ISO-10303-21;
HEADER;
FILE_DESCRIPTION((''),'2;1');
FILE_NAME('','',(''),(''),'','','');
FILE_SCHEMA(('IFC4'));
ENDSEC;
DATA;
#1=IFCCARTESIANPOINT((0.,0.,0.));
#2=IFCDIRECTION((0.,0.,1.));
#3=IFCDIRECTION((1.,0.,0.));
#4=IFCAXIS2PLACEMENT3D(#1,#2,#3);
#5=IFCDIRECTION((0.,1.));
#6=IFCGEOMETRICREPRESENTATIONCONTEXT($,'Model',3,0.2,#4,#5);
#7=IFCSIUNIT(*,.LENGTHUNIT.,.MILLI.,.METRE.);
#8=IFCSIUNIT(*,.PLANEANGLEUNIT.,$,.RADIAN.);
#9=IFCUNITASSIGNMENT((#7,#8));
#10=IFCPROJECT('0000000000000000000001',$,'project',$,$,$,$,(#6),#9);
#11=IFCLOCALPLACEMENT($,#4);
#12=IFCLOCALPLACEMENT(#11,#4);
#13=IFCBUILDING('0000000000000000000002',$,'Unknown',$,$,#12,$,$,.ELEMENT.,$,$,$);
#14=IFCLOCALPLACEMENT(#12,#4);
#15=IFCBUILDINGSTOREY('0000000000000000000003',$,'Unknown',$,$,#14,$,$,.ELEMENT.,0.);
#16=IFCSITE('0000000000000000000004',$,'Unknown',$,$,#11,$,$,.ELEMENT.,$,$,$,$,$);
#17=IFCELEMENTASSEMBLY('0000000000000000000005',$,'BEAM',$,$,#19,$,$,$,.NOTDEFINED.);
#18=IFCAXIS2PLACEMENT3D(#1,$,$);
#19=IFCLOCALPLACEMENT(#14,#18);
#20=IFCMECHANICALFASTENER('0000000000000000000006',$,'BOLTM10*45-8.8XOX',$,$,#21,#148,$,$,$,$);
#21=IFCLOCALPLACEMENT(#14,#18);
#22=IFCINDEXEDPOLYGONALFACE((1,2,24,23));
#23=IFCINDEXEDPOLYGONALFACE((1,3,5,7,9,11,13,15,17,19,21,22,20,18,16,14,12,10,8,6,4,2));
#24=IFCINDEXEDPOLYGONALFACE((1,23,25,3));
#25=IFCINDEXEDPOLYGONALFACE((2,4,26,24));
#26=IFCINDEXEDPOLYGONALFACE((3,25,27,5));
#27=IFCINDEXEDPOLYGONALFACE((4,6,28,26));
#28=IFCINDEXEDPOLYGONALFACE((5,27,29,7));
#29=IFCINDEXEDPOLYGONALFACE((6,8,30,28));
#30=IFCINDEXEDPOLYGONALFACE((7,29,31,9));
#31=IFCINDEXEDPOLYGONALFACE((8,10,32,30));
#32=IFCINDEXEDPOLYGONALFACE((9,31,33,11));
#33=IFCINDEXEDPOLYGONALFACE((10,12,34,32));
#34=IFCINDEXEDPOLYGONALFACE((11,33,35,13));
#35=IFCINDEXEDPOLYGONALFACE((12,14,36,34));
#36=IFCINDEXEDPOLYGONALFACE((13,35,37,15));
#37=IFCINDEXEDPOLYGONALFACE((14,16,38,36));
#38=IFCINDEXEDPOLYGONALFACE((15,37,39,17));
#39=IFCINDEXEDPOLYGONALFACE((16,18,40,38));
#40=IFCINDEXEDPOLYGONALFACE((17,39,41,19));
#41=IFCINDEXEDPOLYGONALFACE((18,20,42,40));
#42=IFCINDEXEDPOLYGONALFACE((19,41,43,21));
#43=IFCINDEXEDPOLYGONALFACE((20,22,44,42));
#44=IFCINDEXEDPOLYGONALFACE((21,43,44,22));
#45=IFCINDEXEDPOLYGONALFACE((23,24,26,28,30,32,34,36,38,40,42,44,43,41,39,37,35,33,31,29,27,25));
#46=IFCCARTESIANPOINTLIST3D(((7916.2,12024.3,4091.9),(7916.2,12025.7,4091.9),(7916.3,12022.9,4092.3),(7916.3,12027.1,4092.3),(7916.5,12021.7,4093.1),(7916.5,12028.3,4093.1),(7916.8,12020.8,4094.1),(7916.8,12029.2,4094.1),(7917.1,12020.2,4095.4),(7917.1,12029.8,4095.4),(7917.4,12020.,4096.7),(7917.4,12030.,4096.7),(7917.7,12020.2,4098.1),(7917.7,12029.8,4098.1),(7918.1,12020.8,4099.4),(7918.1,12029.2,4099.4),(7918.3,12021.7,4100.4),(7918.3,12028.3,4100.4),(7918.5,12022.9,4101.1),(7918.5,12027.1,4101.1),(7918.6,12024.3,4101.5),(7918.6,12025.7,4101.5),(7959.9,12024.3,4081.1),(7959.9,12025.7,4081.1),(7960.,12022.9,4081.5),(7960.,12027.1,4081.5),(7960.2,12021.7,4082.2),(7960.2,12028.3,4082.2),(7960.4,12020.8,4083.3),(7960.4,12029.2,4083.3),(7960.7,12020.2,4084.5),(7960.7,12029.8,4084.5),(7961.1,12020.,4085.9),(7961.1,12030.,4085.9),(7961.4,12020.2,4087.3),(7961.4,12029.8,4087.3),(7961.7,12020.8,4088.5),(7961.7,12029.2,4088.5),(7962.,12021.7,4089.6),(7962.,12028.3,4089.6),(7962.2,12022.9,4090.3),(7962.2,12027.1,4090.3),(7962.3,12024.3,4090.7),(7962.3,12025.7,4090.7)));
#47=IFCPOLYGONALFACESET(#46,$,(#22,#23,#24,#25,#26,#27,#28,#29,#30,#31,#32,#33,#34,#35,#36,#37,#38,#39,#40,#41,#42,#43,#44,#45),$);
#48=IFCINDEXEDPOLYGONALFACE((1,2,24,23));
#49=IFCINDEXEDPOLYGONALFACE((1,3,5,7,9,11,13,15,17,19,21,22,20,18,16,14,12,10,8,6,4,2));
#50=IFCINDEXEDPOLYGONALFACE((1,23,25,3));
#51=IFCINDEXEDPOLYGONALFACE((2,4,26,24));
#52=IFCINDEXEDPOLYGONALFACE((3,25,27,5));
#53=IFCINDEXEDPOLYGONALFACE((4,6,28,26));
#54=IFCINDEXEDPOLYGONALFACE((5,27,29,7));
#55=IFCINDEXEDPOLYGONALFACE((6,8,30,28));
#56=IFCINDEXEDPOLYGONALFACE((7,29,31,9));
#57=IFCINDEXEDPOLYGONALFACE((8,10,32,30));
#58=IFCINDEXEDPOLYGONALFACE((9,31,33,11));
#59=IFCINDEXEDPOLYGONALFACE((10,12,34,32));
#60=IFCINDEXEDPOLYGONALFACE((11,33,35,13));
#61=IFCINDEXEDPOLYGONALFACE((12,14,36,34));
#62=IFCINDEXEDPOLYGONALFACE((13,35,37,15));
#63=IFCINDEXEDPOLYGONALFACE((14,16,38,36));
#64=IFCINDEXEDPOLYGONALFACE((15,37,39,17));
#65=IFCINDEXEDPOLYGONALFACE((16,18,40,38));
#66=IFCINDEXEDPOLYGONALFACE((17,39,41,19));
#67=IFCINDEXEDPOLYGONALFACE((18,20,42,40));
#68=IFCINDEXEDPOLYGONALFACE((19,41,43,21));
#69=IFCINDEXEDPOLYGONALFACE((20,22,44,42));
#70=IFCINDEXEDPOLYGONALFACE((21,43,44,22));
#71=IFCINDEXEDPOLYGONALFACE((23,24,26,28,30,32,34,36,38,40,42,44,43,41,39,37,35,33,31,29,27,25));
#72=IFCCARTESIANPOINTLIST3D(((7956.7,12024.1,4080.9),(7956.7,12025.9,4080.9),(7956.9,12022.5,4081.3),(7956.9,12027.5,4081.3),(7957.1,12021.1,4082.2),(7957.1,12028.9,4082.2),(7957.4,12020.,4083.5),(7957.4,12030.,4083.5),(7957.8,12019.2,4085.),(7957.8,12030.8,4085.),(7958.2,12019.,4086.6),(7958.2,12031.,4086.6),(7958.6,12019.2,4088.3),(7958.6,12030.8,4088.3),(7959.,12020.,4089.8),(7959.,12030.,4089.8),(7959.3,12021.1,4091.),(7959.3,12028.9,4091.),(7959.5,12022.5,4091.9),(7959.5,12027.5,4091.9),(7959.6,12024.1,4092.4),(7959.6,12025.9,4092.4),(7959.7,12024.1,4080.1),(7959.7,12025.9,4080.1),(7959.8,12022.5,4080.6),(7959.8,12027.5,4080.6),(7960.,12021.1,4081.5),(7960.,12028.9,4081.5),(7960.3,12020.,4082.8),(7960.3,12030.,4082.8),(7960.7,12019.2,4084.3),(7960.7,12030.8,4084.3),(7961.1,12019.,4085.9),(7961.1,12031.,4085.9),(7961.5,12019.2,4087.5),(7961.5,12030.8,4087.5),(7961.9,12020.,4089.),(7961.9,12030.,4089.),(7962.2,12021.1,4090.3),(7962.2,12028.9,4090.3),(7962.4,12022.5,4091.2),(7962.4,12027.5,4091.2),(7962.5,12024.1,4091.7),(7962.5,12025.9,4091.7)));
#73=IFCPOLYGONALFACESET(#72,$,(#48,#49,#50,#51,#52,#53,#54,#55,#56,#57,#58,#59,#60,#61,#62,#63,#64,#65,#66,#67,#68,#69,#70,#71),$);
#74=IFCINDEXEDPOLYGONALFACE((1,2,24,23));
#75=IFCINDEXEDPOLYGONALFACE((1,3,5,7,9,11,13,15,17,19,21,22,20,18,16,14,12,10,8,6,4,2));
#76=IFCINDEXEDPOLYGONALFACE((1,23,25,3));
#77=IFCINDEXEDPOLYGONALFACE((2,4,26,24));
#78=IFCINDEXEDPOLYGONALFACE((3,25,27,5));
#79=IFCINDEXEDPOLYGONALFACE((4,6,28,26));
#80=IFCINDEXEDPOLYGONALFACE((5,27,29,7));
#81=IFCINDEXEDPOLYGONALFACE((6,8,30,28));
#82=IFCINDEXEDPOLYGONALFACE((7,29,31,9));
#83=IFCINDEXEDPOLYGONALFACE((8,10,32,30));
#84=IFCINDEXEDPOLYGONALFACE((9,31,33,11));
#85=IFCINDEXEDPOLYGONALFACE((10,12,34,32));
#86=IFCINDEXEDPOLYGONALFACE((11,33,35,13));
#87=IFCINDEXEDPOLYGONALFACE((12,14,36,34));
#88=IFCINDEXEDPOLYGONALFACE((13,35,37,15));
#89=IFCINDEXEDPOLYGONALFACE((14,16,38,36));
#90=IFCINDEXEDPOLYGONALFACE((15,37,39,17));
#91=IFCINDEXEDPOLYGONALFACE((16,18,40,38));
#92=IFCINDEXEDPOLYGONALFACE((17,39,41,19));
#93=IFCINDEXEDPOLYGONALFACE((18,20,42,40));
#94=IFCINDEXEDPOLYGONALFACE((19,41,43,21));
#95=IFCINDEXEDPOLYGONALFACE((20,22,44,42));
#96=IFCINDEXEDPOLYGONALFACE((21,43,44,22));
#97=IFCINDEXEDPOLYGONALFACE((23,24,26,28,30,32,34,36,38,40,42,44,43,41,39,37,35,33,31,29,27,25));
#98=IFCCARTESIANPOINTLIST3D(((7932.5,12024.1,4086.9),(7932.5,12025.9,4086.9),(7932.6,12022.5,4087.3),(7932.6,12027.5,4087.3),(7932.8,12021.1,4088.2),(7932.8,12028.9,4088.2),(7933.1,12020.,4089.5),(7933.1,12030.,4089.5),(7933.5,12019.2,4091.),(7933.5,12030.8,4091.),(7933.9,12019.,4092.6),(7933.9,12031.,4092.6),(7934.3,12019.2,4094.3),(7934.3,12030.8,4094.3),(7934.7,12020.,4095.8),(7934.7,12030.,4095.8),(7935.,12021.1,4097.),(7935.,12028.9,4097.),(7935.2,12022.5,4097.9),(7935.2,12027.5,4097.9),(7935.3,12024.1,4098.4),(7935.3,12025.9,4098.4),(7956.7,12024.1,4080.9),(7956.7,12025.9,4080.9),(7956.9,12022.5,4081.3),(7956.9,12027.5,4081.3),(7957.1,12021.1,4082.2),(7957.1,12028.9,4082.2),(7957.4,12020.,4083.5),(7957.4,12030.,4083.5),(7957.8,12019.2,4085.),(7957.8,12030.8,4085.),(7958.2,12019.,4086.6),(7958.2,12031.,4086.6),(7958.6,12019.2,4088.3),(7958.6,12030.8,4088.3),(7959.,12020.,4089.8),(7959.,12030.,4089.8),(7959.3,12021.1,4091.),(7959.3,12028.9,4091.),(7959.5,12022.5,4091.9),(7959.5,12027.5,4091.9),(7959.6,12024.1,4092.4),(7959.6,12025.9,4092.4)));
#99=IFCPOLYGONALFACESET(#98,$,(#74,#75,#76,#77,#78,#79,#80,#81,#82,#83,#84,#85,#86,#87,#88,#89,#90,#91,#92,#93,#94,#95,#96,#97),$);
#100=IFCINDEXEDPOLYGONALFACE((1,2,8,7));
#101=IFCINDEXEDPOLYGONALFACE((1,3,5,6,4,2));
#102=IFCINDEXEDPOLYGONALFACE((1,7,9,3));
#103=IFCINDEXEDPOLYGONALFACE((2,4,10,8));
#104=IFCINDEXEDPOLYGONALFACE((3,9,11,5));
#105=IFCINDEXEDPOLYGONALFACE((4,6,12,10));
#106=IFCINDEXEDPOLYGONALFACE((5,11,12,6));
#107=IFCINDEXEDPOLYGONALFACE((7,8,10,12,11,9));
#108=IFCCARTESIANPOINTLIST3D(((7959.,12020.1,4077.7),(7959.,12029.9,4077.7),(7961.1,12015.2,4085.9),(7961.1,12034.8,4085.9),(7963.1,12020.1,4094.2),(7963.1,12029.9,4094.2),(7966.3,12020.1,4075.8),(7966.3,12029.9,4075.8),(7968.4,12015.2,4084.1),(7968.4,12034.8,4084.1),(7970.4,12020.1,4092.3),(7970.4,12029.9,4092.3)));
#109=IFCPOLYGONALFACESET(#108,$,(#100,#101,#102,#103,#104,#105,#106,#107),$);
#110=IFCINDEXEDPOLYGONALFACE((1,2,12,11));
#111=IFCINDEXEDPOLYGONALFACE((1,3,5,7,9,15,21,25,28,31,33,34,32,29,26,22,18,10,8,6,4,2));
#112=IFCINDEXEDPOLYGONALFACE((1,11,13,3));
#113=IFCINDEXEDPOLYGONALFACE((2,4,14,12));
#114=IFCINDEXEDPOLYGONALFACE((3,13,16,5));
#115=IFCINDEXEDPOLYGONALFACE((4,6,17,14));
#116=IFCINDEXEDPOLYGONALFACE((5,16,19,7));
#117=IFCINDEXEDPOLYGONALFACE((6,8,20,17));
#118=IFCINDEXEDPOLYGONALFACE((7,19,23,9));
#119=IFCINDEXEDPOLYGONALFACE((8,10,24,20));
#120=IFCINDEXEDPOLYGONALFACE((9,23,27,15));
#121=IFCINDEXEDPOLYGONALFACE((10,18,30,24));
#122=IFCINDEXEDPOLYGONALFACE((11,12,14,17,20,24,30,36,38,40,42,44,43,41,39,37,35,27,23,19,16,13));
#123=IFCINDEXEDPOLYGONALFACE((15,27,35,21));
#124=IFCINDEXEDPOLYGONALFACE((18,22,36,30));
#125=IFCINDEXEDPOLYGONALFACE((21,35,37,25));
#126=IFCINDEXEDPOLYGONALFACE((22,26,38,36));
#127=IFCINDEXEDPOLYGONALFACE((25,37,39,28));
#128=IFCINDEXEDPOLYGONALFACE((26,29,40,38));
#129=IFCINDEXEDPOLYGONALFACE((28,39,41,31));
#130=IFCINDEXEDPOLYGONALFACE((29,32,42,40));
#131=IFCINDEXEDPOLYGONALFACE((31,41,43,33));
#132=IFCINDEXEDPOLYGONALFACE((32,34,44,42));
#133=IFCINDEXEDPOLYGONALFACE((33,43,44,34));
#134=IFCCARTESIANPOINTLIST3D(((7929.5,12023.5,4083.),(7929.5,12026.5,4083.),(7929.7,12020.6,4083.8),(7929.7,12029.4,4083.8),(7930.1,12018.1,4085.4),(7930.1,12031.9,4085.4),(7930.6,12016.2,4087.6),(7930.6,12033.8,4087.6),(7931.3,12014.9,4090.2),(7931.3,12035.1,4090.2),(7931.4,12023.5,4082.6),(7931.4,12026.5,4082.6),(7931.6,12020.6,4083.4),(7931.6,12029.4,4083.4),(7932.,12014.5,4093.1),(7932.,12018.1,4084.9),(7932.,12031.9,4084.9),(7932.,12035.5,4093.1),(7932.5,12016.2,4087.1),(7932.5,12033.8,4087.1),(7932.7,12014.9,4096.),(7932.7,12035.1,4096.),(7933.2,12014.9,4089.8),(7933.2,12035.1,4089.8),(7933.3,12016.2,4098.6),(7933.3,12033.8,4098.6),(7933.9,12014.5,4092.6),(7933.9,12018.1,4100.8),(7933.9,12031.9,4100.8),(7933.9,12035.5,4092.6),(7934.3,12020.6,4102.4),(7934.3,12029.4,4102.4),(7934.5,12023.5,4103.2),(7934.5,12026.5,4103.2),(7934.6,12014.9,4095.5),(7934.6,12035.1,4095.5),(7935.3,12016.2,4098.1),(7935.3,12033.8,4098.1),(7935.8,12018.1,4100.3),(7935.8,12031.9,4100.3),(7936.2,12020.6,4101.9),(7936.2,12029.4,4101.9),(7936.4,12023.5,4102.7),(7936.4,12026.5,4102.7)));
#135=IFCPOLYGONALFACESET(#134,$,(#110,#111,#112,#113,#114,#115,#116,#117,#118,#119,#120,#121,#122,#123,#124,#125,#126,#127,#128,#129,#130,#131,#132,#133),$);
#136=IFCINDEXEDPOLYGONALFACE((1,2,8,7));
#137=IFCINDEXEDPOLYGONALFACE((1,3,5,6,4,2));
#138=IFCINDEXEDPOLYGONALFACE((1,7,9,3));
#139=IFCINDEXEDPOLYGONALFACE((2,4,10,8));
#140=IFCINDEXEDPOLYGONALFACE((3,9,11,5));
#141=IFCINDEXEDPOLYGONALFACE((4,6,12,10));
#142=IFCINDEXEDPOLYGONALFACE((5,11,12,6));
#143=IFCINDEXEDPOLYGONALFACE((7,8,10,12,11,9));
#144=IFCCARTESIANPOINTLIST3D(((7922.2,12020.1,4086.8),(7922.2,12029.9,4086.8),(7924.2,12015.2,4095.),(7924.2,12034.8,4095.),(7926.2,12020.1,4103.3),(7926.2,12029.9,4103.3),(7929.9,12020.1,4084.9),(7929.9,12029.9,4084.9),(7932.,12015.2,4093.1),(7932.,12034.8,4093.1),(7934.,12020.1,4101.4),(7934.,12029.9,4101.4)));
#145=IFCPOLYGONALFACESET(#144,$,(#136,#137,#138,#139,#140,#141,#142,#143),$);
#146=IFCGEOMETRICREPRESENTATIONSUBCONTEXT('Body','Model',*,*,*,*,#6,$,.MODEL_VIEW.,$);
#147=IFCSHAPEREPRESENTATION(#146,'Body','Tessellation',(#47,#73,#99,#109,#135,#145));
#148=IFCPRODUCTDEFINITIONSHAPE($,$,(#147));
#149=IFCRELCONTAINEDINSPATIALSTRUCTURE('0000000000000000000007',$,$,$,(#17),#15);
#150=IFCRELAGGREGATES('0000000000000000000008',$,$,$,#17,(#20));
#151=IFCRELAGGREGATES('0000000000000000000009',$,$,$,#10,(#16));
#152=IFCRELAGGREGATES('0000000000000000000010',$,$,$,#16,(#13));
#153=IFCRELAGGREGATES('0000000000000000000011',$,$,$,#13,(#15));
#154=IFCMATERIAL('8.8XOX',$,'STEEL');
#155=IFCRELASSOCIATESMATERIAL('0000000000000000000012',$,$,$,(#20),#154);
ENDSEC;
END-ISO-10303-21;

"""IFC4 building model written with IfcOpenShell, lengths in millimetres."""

from ifc_helpers import new_model, si_unit, direction, frame, origin_with_axes, place, context, subcontext, project, spatial, line, arc, indexed_curve, outline, extrude, source, transform, mapped, material, element, aggregate, save


model = new_model("IFC4")

# Units and contexts
model_context = context("Model", 3, precision=0.2, world=origin_with_axes(), true_north=direction((0.0, 1.0)))
body_context = subcontext(model_context, "Body", "Model", "MODEL_VIEW")
ifc_project = project(units=[si_unit("LENGTHUNIT", "METRE", prefix="MILLI"), si_unit("PLANEANGLEUNIT", "RADIAN")], contexts=[model_context])

# Site, building, storey
site_placement = place(None, origin_with_axes())
site = spatial("IfcSite", under=ifc_project, at=site_placement, Name="Unknown", CompositionType="ELEMENT")
building_placement = place(site_placement, origin_with_axes())
building = spatial("IfcBuilding", under=site, at=building_placement, Name="Unknown", CompositionType="ELEMENT")
storey_placement = place(building_placement, origin_with_axes())
storey = spatial("IfcBuildingStorey", under=building, at=storey_placement, Name="Unknown", CompositionType="ELEMENT", Elevation=0.0)

# Shared definitions
ifc_material_1 = material(Name="8.8XOX", Category="STEEL")

# Element assembly, mechanical fastener
shared_shape_1 = source(origin_with_axes(), body_context, "Body", "SweptSolid", [
    extrude(outline(indexed_curve([(5.0, 0.0), (0.0, 5.0), (-5.0, 0.0), (0.0, -5.0)], segments=[arc(1, 2, 3), arc(3, 4, 1)])), frame((0.0, 0.0, 3.8), z_axis=(0.0, 0.0, -1.0), x_axis=(0.0, 1.0, 0.0)), (0.0, 0.0, 1.0), 45.0),
    extrude(outline(indexed_curve([(6.0, 0.0), (0.0, 6.0), (-6.0, 0.0), (0.0, -6.0)], segments=[arc(1, 2, 3), arc(3, 4, 1)])), frame((0.0, 0.0, 3.8), z_axis=(0.0, 0.0, -1.0), x_axis=(0.0, 1.0, 0.0)), (0.0, 0.0, 1.0), 3.0),
    extrude(outline(indexed_curve([(6.0, 0.0), (0.0, 6.0), (-6.0, 0.0), (0.0, -6.0)], segments=[arc(1, 2, 3), arc(3, 4, 1)])), frame((0.0, 0.0, 0.8), z_axis=(0.0, 0.0, -1.0), x_axis=(0.0, 1.0, 0.0)), (0.0, 0.0, 1.0), 25.0),
    extrude(outline(indexed_curve([(9.8, 0.0), (4.9, 8.5), (-4.9, 8.5), (-9.8, 0.0), (-4.9, -8.5), (4.9, -8.5)], segments=[line(1, 2, 3, 4, 5, 6, 1)])), frame((0.0, 0.0, 11.2), z_axis=(0.0, 0.0, -1.0), x_axis=(0.0, 1.0, 0.0)), (0.0, 0.0, 1.0), 7.5),
    extrude(outline(indexed_curve([(10.5, 0.0), (0.0, 10.5), (-10.5, 0.0), (0.0, -10.5)], segments=[arc(1, 2, 3), arc(3, 4, 1)])), frame((0.0, 0.0, -24.2), z_axis=(0.0, 0.0, -1.0), x_axis=(0.0, 1.0, 0.0)), (0.0, 0.0, 1.0), 2.0),
    extrude(outline(indexed_curve([(9.8, 0.0), (4.9, 8.5), (-4.9, 8.5), (-9.8, 0.0), (-4.9, -8.5), (4.9, -8.5)], segments=[line(1, 2, 3, 4, 5, 6, 1)])), frame((0.0, 0.0, -26.2), z_axis=(0.0, 0.0, -1.0), x_axis=(0.0, 1.0, 0.0)), (0.0, 0.0, 1.0), 8.0),
])
assembly_1_placement = place(storey_placement, frame((7947.2, 12000.0, 4094.5), z_axis=(0.970613, 0.0, -0.240648), x_axis=(0.0, 1.0, 0.0)))
assembly_1 = element("IfcElementAssembly", 1, at=assembly_1_placement, inside=storey, Name="BEAM", PredefinedType="NOTDEFINED")
mechanical_fastener_1_placement = place(assembly_1_placement, frame((25.0, -5.0, 11.8), z_axis=(0.0, 0.0, 1.0), x_axis=(0.0, 1.0, 0.0)))
mechanical_fastener_1 = element("IfcMechanicalFastener", 2, at=mechanical_fastener_1_placement, material=ifc_material_1, Name="BOLTM10*45-8.8XOX", context=body_context, shape_type="MappedRepresentation", body=[
    mapped(shared_shape_1, transform((0.0, 0.0, 0.0))),
])
aggregate(assembly_1, [mechanical_fastener_1])

save(model, "model.ifc")
